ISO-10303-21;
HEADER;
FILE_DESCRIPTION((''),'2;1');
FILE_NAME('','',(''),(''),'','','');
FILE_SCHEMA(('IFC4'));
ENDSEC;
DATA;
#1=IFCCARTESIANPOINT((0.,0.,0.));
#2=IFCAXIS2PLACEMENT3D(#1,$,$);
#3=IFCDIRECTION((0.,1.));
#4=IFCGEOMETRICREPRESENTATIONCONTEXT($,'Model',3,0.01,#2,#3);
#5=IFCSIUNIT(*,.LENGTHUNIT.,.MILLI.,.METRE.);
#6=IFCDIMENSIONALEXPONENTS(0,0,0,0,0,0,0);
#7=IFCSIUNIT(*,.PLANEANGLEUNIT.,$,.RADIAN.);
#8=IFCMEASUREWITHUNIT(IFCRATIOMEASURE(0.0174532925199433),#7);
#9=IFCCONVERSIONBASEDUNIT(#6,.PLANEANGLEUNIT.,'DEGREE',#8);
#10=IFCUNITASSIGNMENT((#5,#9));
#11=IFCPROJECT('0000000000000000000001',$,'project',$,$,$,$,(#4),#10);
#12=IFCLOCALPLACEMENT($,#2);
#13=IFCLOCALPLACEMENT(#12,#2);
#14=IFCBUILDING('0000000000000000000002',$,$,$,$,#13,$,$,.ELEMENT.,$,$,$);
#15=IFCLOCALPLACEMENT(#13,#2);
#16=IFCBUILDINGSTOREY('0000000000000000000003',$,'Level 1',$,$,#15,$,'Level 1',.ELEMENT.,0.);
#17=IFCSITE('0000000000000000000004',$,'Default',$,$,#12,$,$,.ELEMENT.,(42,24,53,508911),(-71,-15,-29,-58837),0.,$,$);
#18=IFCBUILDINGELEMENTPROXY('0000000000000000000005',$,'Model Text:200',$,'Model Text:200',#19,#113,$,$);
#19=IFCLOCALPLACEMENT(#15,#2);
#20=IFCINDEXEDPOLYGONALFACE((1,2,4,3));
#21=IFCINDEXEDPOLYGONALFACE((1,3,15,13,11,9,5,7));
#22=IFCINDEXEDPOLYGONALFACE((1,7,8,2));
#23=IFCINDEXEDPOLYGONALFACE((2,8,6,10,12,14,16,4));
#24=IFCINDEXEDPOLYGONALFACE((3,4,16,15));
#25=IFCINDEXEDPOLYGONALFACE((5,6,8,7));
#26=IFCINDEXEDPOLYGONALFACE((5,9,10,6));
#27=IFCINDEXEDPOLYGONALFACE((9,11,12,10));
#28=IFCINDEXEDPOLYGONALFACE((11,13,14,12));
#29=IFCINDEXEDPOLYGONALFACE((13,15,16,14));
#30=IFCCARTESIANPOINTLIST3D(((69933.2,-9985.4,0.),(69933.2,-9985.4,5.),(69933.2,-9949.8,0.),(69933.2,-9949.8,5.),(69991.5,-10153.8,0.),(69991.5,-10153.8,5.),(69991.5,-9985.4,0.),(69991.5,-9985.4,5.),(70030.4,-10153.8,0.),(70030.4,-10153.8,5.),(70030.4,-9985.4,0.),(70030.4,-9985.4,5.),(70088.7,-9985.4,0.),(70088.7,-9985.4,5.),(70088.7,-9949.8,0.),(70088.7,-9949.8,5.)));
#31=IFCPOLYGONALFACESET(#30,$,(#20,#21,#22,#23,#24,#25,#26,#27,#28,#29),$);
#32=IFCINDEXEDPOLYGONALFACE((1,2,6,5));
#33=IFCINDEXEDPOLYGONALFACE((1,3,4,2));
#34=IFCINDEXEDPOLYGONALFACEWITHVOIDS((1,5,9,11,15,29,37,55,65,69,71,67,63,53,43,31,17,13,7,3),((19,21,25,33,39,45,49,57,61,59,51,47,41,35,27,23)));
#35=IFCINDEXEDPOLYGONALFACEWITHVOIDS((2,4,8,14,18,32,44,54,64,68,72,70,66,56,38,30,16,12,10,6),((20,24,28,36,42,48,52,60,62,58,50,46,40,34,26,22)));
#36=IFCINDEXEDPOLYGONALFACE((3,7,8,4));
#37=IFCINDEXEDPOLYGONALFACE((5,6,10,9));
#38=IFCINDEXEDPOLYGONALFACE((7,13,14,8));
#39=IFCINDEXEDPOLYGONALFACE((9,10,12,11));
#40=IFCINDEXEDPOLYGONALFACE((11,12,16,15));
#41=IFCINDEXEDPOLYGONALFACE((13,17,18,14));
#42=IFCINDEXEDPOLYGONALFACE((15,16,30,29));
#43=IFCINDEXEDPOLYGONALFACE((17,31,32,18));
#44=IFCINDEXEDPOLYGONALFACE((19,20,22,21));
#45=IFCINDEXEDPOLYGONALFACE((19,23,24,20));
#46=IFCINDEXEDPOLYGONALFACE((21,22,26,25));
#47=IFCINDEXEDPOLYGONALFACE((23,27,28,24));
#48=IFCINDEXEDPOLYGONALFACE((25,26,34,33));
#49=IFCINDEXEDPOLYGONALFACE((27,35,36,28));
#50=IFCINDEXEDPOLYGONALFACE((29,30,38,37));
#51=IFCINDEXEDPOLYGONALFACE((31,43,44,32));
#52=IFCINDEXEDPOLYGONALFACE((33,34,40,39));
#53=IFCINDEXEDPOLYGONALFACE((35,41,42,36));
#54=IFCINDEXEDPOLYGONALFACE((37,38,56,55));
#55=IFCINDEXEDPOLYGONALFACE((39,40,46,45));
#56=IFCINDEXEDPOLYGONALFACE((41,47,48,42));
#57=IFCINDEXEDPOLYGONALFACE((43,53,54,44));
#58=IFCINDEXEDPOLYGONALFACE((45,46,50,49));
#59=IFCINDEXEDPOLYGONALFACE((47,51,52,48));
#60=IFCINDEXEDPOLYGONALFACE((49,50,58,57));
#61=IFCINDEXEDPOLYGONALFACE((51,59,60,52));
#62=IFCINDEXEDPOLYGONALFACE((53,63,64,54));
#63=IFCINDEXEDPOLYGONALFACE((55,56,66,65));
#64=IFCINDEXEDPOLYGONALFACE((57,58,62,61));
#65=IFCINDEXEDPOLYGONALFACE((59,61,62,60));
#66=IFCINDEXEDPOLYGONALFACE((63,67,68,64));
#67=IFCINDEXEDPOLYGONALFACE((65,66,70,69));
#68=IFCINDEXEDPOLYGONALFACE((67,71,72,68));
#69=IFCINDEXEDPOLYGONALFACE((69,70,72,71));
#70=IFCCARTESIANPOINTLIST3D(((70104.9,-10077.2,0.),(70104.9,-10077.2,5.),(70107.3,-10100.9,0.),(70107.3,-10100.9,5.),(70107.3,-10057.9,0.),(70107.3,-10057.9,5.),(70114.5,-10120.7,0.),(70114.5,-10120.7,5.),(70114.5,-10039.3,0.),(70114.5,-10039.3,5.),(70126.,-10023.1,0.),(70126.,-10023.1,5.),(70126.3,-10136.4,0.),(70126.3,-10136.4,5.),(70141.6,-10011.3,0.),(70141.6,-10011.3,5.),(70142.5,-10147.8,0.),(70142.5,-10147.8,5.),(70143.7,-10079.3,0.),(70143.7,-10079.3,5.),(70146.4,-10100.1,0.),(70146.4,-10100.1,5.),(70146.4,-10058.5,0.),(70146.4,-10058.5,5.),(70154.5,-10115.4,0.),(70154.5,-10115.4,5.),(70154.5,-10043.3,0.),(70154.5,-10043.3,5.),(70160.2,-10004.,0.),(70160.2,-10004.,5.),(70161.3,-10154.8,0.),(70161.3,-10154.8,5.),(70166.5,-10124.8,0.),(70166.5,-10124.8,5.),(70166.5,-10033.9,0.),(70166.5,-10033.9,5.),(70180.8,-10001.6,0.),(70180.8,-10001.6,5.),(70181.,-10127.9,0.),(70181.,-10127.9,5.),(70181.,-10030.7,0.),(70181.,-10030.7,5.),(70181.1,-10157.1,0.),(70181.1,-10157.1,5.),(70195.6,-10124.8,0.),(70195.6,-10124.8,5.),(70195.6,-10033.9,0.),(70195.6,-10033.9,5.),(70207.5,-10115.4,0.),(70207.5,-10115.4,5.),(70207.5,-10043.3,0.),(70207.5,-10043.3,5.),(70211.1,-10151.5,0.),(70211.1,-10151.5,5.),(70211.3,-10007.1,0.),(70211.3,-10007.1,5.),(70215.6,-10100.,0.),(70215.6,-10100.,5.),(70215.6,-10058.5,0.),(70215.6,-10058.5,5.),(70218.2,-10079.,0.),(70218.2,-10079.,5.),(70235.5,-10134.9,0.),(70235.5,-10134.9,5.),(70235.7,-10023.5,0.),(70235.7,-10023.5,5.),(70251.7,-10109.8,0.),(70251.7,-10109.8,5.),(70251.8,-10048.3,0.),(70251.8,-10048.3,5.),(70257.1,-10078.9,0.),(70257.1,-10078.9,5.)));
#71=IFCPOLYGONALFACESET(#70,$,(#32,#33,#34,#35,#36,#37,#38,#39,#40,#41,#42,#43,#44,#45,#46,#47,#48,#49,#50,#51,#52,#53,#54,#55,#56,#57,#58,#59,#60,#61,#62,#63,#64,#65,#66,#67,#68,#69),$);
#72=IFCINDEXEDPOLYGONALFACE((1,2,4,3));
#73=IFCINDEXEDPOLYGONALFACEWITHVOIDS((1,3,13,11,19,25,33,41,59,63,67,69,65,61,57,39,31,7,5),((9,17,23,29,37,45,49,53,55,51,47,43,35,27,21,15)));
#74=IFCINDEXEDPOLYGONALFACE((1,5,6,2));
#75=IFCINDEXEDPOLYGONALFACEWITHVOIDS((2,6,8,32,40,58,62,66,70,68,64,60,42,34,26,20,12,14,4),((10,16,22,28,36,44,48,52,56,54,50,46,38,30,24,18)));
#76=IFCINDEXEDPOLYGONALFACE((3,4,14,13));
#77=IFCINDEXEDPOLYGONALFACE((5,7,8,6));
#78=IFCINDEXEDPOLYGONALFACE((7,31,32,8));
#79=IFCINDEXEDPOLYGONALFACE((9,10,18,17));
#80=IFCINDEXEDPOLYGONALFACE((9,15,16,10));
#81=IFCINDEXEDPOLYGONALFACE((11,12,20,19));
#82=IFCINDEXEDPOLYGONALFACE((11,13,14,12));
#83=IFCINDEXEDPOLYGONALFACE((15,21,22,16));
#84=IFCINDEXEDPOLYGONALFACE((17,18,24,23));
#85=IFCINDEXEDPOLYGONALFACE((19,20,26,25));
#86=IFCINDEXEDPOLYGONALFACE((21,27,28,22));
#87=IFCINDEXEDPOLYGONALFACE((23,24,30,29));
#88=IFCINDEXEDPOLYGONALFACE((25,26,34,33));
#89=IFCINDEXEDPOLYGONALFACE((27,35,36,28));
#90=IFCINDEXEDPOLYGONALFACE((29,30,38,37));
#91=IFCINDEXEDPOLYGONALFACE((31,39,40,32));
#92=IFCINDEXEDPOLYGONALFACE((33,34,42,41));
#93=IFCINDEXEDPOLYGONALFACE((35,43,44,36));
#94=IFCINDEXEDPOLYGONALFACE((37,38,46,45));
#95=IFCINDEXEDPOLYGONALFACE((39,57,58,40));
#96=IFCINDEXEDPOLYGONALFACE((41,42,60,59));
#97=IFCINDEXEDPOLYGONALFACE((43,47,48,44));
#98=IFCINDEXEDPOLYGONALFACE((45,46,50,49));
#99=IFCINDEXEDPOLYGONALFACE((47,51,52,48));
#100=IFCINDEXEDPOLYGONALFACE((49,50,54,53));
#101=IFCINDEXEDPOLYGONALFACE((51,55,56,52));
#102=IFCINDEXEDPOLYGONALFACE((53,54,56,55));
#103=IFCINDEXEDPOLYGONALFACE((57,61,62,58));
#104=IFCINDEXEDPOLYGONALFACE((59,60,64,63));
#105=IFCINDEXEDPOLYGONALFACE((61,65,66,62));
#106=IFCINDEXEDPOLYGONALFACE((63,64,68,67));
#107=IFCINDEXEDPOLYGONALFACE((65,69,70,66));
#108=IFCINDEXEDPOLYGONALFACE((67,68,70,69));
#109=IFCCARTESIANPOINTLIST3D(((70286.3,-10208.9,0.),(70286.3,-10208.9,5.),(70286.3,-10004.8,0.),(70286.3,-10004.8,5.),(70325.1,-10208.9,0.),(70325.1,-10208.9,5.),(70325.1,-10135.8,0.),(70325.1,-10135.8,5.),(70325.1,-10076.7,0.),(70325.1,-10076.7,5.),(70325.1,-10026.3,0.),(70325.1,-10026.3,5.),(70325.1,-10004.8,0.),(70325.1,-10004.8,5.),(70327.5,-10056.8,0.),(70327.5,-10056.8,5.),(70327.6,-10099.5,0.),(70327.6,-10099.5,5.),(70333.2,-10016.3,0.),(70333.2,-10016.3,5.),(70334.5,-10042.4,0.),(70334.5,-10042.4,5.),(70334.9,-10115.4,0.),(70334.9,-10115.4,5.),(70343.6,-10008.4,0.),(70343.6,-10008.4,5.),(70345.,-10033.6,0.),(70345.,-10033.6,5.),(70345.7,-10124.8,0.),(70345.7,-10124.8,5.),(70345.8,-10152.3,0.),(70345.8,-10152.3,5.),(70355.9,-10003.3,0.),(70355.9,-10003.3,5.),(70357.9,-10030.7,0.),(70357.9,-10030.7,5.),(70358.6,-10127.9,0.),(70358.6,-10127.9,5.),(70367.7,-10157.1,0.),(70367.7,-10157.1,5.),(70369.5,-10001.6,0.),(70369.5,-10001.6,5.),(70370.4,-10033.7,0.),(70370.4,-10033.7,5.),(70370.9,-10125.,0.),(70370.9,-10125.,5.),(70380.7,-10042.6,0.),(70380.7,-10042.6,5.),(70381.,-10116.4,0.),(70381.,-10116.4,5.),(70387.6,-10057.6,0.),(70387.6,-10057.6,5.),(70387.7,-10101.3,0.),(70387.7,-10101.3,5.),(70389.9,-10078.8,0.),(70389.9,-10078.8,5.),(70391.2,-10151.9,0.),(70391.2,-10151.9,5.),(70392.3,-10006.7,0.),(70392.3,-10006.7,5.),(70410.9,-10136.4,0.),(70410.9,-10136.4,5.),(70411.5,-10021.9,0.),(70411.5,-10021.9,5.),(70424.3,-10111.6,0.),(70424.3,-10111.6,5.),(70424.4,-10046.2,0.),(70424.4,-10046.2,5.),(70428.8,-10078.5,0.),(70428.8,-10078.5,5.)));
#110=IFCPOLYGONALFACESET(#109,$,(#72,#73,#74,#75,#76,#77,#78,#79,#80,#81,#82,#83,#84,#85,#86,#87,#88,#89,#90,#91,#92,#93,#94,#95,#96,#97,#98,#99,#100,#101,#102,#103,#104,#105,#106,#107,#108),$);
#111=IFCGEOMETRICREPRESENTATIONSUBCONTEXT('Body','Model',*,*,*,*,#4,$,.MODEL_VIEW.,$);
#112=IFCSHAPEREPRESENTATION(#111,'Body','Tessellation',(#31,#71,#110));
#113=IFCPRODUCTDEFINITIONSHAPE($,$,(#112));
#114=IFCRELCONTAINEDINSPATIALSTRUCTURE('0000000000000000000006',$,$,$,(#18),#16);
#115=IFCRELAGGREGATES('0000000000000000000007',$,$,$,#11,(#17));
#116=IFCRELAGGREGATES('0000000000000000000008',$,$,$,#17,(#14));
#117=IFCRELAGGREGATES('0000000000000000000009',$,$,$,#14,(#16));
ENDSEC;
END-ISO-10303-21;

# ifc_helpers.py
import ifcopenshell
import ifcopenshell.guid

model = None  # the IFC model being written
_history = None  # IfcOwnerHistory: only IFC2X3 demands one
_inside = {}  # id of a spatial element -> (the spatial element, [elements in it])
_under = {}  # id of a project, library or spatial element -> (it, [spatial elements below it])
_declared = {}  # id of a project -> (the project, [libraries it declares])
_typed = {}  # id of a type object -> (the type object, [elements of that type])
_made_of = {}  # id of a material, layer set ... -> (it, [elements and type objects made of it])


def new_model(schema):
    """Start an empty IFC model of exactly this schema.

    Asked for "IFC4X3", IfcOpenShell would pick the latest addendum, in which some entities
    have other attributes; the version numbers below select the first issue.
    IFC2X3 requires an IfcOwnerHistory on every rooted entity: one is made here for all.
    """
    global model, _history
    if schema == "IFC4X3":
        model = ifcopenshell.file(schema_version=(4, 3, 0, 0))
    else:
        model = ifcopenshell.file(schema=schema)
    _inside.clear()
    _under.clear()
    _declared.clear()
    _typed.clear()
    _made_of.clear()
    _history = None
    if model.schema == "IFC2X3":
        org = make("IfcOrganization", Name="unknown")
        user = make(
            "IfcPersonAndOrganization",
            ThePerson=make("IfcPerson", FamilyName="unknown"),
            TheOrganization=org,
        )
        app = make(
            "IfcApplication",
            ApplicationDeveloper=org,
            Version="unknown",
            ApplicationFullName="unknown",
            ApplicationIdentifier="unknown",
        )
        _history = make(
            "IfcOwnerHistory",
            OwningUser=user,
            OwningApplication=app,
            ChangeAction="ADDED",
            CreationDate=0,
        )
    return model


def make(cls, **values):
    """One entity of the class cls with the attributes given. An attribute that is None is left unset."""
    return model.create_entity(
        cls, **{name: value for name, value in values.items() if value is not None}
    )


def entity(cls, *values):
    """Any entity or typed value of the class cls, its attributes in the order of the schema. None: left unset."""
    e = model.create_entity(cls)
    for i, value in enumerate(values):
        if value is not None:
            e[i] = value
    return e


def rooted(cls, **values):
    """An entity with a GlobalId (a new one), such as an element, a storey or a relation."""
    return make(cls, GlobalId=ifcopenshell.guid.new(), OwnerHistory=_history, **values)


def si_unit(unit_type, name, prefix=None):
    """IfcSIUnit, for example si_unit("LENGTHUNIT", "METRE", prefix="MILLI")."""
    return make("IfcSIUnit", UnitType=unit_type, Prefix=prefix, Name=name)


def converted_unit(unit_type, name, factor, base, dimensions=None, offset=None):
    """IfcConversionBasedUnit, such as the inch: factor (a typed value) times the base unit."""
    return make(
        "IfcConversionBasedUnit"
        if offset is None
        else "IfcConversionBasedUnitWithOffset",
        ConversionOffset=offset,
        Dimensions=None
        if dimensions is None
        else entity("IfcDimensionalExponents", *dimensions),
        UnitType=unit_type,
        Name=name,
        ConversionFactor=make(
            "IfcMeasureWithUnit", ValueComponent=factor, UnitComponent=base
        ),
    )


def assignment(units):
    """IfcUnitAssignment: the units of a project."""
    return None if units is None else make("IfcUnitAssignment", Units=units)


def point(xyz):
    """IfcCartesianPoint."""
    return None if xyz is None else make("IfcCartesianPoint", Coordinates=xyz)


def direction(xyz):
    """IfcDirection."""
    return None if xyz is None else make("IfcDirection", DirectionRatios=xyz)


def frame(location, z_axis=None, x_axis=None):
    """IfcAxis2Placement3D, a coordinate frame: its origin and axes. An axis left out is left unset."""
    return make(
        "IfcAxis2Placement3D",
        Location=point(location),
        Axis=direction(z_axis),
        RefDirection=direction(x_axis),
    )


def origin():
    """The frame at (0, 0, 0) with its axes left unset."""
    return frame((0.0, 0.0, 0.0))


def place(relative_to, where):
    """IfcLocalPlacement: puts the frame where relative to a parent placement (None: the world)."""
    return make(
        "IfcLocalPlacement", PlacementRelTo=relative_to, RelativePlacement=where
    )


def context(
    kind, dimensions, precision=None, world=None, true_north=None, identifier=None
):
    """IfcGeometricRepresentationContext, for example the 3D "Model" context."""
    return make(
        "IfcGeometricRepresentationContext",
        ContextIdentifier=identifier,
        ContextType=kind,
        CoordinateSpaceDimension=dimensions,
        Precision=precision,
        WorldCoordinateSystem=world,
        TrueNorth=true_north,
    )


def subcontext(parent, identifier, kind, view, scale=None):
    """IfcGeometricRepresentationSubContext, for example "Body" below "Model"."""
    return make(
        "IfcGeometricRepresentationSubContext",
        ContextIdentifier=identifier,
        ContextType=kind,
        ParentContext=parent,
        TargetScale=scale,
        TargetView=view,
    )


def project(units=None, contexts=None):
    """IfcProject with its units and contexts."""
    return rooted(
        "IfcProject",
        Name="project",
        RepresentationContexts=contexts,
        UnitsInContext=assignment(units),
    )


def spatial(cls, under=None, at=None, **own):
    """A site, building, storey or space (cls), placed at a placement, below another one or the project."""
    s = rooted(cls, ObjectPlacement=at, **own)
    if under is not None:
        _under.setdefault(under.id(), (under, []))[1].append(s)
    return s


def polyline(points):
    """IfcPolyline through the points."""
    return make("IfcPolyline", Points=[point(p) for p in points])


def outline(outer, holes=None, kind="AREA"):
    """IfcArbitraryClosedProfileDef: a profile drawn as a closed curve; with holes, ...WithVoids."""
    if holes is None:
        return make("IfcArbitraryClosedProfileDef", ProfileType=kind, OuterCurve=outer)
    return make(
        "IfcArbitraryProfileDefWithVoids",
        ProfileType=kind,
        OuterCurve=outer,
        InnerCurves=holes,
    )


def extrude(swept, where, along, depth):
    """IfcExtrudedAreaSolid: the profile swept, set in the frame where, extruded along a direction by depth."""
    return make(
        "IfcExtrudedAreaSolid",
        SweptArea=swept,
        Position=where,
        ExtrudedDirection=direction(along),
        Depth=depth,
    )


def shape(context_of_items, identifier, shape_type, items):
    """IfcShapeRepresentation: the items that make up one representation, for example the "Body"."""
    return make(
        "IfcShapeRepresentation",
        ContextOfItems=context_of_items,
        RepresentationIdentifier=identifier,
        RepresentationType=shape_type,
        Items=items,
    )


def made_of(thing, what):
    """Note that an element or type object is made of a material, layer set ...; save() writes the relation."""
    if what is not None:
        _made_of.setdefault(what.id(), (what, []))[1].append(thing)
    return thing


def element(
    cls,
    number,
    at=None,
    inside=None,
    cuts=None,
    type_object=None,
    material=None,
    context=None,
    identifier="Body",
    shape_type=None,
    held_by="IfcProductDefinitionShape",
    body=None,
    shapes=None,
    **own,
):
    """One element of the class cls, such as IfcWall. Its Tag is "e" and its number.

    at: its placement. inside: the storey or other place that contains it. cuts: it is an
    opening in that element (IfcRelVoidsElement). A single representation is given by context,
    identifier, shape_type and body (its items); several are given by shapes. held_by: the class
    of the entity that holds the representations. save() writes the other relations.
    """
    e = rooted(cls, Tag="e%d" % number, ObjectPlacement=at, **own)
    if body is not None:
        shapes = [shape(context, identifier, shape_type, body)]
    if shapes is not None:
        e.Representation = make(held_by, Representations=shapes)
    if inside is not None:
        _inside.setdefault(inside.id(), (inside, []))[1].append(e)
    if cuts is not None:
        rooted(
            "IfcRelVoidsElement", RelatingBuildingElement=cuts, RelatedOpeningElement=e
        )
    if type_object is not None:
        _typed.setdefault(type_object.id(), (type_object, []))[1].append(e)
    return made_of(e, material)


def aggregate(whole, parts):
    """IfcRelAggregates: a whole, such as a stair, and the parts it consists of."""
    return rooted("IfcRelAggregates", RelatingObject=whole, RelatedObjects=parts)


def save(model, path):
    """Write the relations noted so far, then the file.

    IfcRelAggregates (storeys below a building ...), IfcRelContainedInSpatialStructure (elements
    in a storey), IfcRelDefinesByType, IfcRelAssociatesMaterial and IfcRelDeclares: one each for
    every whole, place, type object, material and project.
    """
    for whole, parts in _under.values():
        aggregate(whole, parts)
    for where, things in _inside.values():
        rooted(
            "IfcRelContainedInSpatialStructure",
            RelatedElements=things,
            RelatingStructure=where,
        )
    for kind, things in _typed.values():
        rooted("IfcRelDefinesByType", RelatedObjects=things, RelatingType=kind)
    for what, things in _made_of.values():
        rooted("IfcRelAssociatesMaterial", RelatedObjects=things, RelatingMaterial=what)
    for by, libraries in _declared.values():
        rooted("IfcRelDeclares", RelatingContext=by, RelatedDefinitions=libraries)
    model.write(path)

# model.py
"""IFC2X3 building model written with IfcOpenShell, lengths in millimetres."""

from ifc_helpers import new_model, entity, si_unit, converted_unit, direction, frame, origin, place, context, subcontext, project, spatial, polyline, outline, extrude, element, save


model = new_model("IFC2X3")

# Units and contexts
model_context = context("Model", 3, precision=0.01, world=origin(), true_north=direction((0.0, 1.0)))
body_context = subcontext(model_context, "Body", "Model", "MODEL_VIEW")
ifc_project = project(units=[si_unit("LENGTHUNIT", "METRE", prefix="MILLI"), converted_unit("PLANEANGLEUNIT", "DEGREE", entity("IfcRatioMeasure", 0.0174532925199433), si_unit("PLANEANGLEUNIT", "RADIAN"), dimensions=[0, 0, 0, 0, 0, 0, 0])], contexts=[model_context])

# Site, building, storey
site_placement = place(None, origin())
site = spatial("IfcSite", under=ifc_project, at=site_placement, Name="Default", CompositionType="ELEMENT", RefLatitude=(42, 24, 53, 508911), RefLongitude=(-71, -15, -29, -58837), RefElevation=0.0)
building_placement = place(site_placement, origin())
building = spatial("IfcBuilding", under=site, at=building_placement, CompositionType="ELEMENT")
storey_placement = place(building_placement, origin())
storey = spatial("IfcBuildingStorey", under=building, at=storey_placement, Name="Level 1", LongName="Level 1", CompositionType="ELEMENT", Elevation=0.0)

# Building element proxy
proxy_1_placement = place(storey_placement, origin())
element("IfcBuildingElementProxy", 1, at=proxy_1_placement, inside=storey, Name="Model Text:200", ObjectType="Model Text:200", context=body_context, shape_type="SweptSolid", body=[
    extrude(outline(polyline([(-19.4, -135.2), (19.4, -135.2), (19.4, 33.2), (77.7, 33.2), (77.7, 68.8), (-77.7, 68.8), (-77.7, 33.2), (-19.4, 33.2), (-19.4, -135.2)])), frame((70010.9, -10018.6, 0.0)), (0.0, 0.0, 1.0), 5.0),
    extrude(outline(polyline([(-8.8, -65.7), (15.1, -65.7), (35.5, -60.5), (52.3, -50.4), (65.3, -35.4), (74.1, -17.3), (78.4, 2.1), (75.9, 32.5), (61.8, 58.5), (38.4, 77.1), (8.3, 85.6), (-22.7, 83.3), (-49.0, 69.9), (-67.8, 47.3), (-76.3, 17.5), (-76.0, -3.3), (-70.7, -22.5), (-60.5, -39.2), (-45.5, -52.3), (-27.7, -61.4), (-8.8, -65.7)]), holes=[polyline([(-2.7, -27.2), (-23.1, -22.5), (-37.5, -12.9), (-45.7, 0.0), (-47.3, 14.8), (-42.7, 28.9), (-32.2, 39.9), (-16.3, 46.3), (4.5, 46.9), (25.1, 42.1), (39.6, 32.6), (47.7, 19.7), (49.4, 5.0), (44.8, -9.2), (34.2, -20.2), (18.2, -26.7), (-2.7, -27.2)])]), frame((70171.1, -10079.3, 0.0), z_axis=(0.0, 0.0, 1.0), x_axis=(0.100608, -0.994926, 0.0)), (0.0, 0.0, 1.0), 5.0),
    extrude(outline(polyline([(-73.1, -75.4), (130.9, -75.4), (130.9, -36.6), (57.8, -36.6), (74.3, -15.9), (79.1, 6.0), (73.9, 29.5), (58.4, 49.2), (33.6, 62.6), (0.5, 67.1), (-31.8, 62.8), (-56.1, 49.8), (-71.3, 30.7), (-76.4, 7.8), (-74.7, -5.8), (-69.6, -18.1), (-61.7, -28.5), (-51.7, -36.6), (-73.1, -36.6), (-73.1, -75.4)]), holes=[polyline([(-1.2, -36.6), (-21.2, -34.2), (-35.6, -27.2), (-44.3, -16.7), (-47.2, -3.8), (-44.3, 8.7), (-35.4, 19.0), (-20.4, 25.9), (0.8, 28.2), (23.3, 26.0), (38.5, 19.3), (47.1, 9.2), (49.9, -3.1), (46.8, -16.0), (37.4, -26.8), (21.5, -34.1), (-1.2, -36.6)])]), frame((70361.7, -10078.0, 0.0), z_axis=(0.0, 0.0, 1.0), x_axis=(0.0, -1.0, 0.0)), (0.0, 0.0, 1.0), 5.0),
])

save(model, "model.ifc")
